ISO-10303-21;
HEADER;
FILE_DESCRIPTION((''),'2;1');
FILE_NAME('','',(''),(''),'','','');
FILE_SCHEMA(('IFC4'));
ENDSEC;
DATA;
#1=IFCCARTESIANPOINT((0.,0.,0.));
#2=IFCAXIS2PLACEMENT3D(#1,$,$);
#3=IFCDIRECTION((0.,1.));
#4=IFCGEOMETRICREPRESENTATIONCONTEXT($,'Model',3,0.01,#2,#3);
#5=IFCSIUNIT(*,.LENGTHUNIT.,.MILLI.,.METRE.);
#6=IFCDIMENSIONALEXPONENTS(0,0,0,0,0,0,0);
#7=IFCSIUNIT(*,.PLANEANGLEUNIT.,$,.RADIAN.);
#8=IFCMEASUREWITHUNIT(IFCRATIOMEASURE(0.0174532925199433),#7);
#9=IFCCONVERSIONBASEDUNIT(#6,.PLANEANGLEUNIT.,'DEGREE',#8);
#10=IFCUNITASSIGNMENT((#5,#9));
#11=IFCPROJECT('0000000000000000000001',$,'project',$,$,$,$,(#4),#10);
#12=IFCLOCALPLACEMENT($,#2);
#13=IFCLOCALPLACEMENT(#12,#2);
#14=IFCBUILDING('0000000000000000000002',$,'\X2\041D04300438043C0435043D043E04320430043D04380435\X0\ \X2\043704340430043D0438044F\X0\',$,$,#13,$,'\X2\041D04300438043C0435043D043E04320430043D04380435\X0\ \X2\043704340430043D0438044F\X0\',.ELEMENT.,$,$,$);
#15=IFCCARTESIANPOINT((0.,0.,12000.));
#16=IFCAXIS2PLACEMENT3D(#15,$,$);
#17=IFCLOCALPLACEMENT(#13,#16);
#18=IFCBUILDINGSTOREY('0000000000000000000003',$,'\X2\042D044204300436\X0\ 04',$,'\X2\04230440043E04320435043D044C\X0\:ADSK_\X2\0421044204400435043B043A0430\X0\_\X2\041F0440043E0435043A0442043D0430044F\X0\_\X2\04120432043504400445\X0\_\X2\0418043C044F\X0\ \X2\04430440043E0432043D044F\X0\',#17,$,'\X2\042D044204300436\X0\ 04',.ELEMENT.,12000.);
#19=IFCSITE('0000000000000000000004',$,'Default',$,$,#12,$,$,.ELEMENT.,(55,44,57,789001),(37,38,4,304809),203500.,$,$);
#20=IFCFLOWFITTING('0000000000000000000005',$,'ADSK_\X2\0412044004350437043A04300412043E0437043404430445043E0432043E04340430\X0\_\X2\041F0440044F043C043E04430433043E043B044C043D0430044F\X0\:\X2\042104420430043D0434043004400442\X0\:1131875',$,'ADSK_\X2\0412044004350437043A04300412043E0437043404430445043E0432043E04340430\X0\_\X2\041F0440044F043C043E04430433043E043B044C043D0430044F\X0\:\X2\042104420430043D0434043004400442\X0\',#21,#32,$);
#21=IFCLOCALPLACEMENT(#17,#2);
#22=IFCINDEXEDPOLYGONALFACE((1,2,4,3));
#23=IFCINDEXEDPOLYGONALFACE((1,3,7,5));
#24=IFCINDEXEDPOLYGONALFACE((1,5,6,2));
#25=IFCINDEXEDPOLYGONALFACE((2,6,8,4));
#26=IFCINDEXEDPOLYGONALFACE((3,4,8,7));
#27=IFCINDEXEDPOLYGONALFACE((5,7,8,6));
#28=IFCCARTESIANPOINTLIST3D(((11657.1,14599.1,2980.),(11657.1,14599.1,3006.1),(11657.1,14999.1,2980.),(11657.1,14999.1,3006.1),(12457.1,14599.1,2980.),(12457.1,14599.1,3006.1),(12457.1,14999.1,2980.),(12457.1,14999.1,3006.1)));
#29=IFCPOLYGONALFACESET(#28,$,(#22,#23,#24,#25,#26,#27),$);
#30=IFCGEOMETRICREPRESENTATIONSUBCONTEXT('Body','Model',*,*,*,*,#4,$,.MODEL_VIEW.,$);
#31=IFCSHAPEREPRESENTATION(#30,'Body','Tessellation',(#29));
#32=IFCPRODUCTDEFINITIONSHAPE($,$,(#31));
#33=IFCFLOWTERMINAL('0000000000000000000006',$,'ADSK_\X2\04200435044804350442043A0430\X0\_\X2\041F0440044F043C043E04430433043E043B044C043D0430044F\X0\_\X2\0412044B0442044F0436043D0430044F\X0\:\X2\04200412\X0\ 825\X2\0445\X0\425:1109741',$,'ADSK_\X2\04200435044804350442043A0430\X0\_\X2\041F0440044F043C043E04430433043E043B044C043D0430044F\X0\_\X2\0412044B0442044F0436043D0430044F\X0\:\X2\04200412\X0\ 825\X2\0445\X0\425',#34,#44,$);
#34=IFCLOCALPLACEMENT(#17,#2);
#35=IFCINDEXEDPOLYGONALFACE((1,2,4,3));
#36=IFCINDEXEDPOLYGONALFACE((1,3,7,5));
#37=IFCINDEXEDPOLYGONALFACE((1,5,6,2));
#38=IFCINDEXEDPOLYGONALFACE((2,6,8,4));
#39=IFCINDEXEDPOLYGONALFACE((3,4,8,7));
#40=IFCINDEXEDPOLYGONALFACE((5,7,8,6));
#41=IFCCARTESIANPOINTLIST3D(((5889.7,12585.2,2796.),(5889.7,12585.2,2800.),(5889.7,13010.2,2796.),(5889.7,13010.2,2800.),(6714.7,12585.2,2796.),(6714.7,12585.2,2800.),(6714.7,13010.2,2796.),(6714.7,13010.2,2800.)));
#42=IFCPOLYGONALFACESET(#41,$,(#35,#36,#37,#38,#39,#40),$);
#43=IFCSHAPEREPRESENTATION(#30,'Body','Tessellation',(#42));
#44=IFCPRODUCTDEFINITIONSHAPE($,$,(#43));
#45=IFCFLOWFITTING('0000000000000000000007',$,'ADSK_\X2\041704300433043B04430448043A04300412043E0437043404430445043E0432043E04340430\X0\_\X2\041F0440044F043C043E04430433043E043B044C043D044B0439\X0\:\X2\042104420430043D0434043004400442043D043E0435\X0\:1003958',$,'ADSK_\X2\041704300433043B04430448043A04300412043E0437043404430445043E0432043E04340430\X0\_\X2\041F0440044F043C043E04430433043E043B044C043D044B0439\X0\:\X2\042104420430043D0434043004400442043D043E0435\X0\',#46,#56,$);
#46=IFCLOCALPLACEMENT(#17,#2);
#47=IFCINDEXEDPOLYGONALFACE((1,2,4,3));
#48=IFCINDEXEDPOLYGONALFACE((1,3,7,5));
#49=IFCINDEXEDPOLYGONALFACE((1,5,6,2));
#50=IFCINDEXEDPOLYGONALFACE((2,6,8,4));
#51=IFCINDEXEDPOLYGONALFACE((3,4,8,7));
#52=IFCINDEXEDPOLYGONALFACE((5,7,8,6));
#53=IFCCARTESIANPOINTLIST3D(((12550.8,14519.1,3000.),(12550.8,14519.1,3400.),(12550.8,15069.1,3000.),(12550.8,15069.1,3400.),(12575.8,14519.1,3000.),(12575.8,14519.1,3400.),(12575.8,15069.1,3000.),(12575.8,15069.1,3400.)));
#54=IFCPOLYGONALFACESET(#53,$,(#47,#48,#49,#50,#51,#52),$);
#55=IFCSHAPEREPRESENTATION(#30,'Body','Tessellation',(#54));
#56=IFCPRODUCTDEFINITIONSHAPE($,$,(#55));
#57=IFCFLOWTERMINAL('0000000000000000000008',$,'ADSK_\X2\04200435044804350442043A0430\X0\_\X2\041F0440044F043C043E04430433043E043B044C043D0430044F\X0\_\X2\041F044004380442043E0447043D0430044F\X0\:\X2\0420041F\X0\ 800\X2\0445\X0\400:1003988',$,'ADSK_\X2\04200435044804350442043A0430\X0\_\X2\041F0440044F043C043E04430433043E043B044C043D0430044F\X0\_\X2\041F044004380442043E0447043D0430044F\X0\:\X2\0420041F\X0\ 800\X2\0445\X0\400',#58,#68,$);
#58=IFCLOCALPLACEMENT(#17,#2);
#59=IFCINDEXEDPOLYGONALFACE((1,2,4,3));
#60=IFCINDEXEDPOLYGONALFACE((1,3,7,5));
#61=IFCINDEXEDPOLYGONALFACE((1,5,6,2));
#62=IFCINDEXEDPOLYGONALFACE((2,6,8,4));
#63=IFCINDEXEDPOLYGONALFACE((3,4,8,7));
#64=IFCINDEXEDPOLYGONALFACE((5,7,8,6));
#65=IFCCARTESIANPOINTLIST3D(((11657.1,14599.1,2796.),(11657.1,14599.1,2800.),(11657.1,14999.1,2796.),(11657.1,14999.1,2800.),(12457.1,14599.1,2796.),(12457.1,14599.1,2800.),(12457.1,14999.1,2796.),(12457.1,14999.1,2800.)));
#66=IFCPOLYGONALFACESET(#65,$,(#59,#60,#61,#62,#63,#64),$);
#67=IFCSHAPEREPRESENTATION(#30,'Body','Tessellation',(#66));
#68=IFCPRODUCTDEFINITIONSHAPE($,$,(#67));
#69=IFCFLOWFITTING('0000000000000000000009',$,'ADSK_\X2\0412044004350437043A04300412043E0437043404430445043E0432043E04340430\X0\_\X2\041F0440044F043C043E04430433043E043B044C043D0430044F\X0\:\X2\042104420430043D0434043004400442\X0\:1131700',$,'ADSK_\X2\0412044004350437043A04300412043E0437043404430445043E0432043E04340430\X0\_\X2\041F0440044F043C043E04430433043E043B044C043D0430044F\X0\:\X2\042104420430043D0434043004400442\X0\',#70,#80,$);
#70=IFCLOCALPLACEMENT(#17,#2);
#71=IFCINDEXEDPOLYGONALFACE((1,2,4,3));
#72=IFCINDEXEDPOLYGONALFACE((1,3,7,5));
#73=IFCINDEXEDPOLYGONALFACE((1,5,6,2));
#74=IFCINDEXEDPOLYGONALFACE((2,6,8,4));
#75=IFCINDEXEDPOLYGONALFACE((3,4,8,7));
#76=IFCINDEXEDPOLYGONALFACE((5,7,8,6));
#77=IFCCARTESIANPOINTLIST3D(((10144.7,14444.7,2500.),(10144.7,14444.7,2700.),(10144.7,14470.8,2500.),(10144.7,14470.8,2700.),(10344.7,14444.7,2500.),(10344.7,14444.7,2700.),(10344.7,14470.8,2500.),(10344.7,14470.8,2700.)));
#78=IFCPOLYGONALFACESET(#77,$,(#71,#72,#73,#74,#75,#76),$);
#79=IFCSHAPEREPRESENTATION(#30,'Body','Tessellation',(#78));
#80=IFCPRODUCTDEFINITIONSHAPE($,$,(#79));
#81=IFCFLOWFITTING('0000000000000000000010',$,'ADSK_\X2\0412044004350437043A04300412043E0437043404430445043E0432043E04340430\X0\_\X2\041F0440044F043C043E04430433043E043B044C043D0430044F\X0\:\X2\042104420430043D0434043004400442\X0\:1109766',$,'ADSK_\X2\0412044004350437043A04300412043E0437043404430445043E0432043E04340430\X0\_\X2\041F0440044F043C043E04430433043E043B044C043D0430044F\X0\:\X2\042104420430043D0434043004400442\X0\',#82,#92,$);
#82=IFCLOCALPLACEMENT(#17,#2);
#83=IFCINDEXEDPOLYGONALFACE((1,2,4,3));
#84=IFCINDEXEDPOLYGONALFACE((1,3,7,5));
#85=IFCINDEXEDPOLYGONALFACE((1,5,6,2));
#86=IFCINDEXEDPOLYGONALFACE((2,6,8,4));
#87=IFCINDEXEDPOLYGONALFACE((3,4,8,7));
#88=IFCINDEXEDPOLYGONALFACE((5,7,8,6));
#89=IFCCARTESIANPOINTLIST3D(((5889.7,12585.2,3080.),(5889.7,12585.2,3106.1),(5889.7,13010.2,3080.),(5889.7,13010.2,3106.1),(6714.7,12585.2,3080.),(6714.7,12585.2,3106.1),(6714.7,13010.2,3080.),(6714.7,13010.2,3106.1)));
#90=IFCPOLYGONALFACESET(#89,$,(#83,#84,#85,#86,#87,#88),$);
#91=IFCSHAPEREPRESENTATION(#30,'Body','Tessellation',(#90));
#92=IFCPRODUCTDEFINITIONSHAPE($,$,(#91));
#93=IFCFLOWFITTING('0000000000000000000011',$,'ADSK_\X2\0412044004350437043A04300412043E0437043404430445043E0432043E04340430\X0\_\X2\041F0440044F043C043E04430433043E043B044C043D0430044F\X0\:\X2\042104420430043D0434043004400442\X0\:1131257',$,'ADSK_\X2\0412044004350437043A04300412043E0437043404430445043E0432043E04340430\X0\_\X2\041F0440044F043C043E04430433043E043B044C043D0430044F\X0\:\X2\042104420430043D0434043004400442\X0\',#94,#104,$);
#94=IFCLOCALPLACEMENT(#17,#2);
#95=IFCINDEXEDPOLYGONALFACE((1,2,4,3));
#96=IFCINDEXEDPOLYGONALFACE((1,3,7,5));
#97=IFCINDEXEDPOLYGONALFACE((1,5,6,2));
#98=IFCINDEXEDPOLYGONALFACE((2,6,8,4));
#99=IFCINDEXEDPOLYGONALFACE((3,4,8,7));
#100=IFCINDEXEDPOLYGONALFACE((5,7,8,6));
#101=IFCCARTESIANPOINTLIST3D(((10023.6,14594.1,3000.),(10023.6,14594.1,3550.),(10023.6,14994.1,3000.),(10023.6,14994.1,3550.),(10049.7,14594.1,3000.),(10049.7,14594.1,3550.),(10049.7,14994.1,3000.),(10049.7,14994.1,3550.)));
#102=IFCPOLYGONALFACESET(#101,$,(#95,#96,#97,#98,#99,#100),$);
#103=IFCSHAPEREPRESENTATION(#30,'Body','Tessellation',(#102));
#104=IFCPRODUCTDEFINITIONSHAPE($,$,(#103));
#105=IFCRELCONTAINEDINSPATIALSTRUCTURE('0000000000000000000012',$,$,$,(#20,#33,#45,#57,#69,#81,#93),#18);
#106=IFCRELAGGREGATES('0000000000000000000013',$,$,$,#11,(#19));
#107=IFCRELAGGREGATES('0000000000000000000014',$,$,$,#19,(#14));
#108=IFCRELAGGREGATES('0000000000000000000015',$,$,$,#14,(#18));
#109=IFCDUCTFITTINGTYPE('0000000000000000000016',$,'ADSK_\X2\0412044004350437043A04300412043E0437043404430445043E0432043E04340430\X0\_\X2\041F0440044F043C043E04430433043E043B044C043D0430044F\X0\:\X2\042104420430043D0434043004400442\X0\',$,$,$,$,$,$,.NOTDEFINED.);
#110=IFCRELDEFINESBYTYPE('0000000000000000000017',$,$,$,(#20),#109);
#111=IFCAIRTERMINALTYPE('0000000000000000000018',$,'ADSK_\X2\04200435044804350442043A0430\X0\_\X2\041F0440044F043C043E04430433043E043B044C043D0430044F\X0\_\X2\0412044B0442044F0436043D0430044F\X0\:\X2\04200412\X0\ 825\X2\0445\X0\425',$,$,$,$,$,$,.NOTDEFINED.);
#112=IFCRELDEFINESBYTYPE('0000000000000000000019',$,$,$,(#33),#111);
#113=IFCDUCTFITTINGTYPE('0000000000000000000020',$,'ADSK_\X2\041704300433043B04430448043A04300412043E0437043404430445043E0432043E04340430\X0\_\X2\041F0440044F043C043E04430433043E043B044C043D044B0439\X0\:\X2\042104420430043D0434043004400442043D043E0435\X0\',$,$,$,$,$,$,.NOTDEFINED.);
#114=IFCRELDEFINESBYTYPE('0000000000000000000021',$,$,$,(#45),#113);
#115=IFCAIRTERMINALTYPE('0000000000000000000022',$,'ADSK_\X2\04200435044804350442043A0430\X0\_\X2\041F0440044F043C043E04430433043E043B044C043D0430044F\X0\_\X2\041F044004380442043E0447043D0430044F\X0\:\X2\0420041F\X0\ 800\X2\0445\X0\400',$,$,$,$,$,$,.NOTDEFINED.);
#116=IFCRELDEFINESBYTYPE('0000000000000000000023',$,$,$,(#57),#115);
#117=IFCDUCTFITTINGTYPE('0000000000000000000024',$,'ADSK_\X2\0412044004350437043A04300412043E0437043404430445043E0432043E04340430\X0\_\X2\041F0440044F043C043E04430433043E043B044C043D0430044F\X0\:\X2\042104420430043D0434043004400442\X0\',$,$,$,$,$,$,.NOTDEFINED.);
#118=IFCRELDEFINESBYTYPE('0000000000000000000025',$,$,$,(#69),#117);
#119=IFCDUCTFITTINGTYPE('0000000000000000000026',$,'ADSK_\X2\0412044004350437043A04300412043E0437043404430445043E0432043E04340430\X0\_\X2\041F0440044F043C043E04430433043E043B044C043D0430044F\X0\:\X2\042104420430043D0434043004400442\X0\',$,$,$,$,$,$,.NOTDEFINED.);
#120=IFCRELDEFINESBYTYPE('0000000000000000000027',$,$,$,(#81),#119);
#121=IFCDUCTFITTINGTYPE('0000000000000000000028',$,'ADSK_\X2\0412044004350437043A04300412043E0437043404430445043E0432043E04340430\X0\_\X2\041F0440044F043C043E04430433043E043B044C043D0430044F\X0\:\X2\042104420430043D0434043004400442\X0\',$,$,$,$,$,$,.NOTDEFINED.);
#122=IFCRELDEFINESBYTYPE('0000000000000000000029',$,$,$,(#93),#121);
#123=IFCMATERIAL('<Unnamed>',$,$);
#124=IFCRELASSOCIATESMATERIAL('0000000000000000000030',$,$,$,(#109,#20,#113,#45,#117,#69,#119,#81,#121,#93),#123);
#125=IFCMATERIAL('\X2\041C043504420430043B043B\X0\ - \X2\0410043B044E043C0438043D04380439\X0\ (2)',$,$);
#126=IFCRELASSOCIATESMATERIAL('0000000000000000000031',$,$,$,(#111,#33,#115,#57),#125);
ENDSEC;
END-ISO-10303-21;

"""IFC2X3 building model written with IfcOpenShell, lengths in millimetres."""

from ifc_helpers import new_model, entity, si_unit, converted_unit, direction, frame, frame_2d, origin, origin_2d_with_axis, place, context, subcontext, project, spatial, rectangle, extrude, source, transform, mapped, material, type_object, type_shapes, element, save


model = new_model("IFC2X3")

# Units and contexts
model_context = context("Model", 3, precision=0.01, world=origin(), true_north=direction((0.0, 1.0)))
body_context = subcontext(model_context, "Body", "Model", "MODEL_VIEW")
ifc_project = project(units=[si_unit("LENGTHUNIT", "METRE", prefix="MILLI"), converted_unit("PLANEANGLEUNIT", "DEGREE", entity("IfcRatioMeasure", 0.0174532925199433), si_unit("PLANEANGLEUNIT", "RADIAN"), dimensions=[0, 0, 0, 0, 0, 0, 0])], contexts=[model_context])

# Site, building, storey
site_placement = place(None, frame((0.0, 0.0, 0.0)))
site = spatial("IfcSite", under=ifc_project, at=site_placement, Name="Default", CompositionType="ELEMENT", RefLatitude=(55, 44, 57, 789001), RefLongitude=(37, 38, 4, 304809), RefElevation=203500.0)
building_placement = place(site_placement, origin())
building = spatial("IfcBuilding", under=site, at=building_placement, Name="Наименование здания", LongName="Наименование здания", CompositionType="ELEMENT")
storey_placement = place(building_placement, frame((0.0, 0.0, 12000.0)))
storey = spatial("IfcBuildingStorey", under=building, at=storey_placement, Name="Этаж 04", ObjectType="Уровень:ADSK_Стрелка_Проектная_Вверх_Имя уровня", LongName="Этаж 04", CompositionType="ELEMENT", Elevation=12000.0)

# Flow fitting
ifc_material_1 = material(Name="<Unnamed>")
duct_fitting_type_1 = type_object("IfcDuctFittingType", Name="ADSK_ВрезкаВоздуховода_Прямоугольная:Стандарт", PredefinedType="NOTDEFINED", material=ifc_material_1)
shared_shape_1 = source(origin(), body_context, "Body", "SweptSolid", [
    extrude(rectangle(XDim=800.0, YDim=26.1, at=frame_2d((0.0, 0.0), x_axis=(1.0, 0.0))), frame((7.0, 0.0, -200.0), z_axis=(0.0, 0.0, 1.0), x_axis=(0.0, -1.0, 0.0)), (0.0, 0.0, 1.0), 400.0),
])
type_shapes(duct_fitting_type_1, [shared_shape_1])
flow_fitting_1_placement = place(storey_placement, frame((12057.1, 14799.1, 3000.0), z_axis=(0.0, 1.0, 0.0), x_axis=(0.0, 0.0, -1.0)))
element("IfcFlowFitting", 1, at=flow_fitting_1_placement, inside=storey, type_object=duct_fitting_type_1, material=ifc_material_1, Name="ADSK_ВрезкаВоздуховода_Прямоугольная:Стандарт:1131875", ObjectType="ADSK_ВрезкаВоздуховода_Прямоугольная:Стандарт", context=body_context, shape_type="MappedRepresentation", body=[
    mapped(shared_shape_1, transform((0.0, 0.0, 0.0), scale=1.0)),
])

# Flow terminal
ifc_material_2 = material(Name="Металл - Алюминий (2)")
air_terminal_type_1 = type_object("IfcAirTerminalType", Name="ADSK_Решетка_Прямоугольная_Вытяжная:РВ 825х425", PredefinedType="NOTDEFINED", material=ifc_material_2)
shared_shape_2 = source(origin(), body_context, "Body", "SweptSolid", [
    extrude(rectangle(XDim=4.0, YDim=825.0, at=origin_2d_with_axis()), frame((0.0, -2.0, -212.5), z_axis=(0.0, 0.0, 1.0), x_axis=(0.0, 1.0, 0.0)), (0.0, 0.0, 1.0), 425.0),
])
type_shapes(air_terminal_type_1, [shared_shape_2])
flow_terminal_1_placement = place(storey_placement, frame((6302.2, 12797.7, 2800.0), z_axis=(0.0, 1.0, 0.0), x_axis=(-1.0, 0.0, 0.0)))
element("IfcFlowTerminal", 2, at=flow_terminal_1_placement, inside=storey, type_object=air_terminal_type_1, material=ifc_material_2, Name="ADSK_Решетка_Прямоугольная_Вытяжная:РВ 825х425:1109741", ObjectType="ADSK_Решетка_Прямоугольная_Вытяжная:РВ 825х425", context=body_context, shape_type="MappedRepresentation", body=[
    mapped(shared_shape_2, transform((0.0, 0.0, 0.0), scale=1.0)),
])

# Flow fitting
duct_fitting_type_2 = type_object("IfcDuctFittingType", Name="ADSK_ЗаглушкаВоздуховода_Прямоугольный:Стандартное", PredefinedType="NOTDEFINED", material=ifc_material_1)
shared_shape_3 = source(origin(), body_context, "Body", "SweptSolid", [
    extrude(rectangle(XDim=25.0, YDim=550.0, at=frame_2d((0.0, 0.0), x_axis=(1.0, 0.0))), frame((12.5, 0.0, -200.0)), (0.0, 0.0, 1.0), 400.0),
])
type_shapes(duct_fitting_type_2, [shared_shape_3])
flow_fitting_2_placement = place(storey_placement, frame((12550.8, 14794.1, 3200.0)))
element("IfcFlowFitting", 3, at=flow_fitting_2_placement, inside=storey, type_object=duct_fitting_type_2, material=ifc_material_1, Name="ADSK_ЗаглушкаВоздуховода_Прямоугольный:Стандартное:1003958", ObjectType="ADSK_ЗаглушкаВоздуховода_Прямоугольный:Стандартное", context=body_context, shape_type="MappedRepresentation", body=[
    mapped(shared_shape_3, transform((0.0, 0.0, 0.0), scale=1.0)),
])

# Flow terminal
air_terminal_type_2 = type_object("IfcAirTerminalType", Name="ADSK_Решетка_Прямоугольная_Приточная:РП 800х400", PredefinedType="NOTDEFINED", material=ifc_material_2)
shared_shape_4 = source(origin(), body_context, "Body", "SweptSolid", [
    extrude(rectangle(XDim=4.0, YDim=800.0, at=origin_2d_with_axis()), frame((0.0, -2.0, -200.0), z_axis=(0.0, 0.0, 1.0), x_axis=(0.0, 1.0, 0.0)), (0.0, 0.0, 1.0), 400.0),
])
type_shapes(air_terminal_type_2, [shared_shape_4])
flow_terminal_2_placement = place(storey_placement, frame((12057.1, 14799.1, 2800.0), z_axis=(0.0, 1.0, 0.0), x_axis=(-1.0, 0.0, 0.0)))
element("IfcFlowTerminal", 4, at=flow_terminal_2_placement, inside=storey, type_object=air_terminal_type_2, material=ifc_material_2, Name="ADSK_Решетка_Прямоугольная_Приточная:РП 800х400:1003988", ObjectType="ADSK_Решетка_Прямоугольная_Приточная:РП 800х400", context=body_context, shape_type="MappedRepresentation", body=[
    mapped(shared_shape_4, transform((0.0, 0.0, 0.0), scale=1.0)),
])

# Flow fittings
duct_fitting_type_3 = type_object("IfcDuctFittingType", Name="ADSK_ВрезкаВоздуховода_Прямоугольная:Стандарт", PredefinedType="NOTDEFINED", material=ifc_material_1)
shared_shape_5 = source(origin(), body_context, "Body", "SweptSolid", [
    extrude(rectangle(XDim=200.0, YDim=26.1, at=frame_2d((0.0, 0.0), x_axis=(1.0, 0.0))), frame((7.0, 0.0, -100.0), z_axis=(0.0, 0.0, 1.0), x_axis=(0.0, -1.0, 0.0)), (0.0, 0.0, 1.0), 200.0),
])
type_shapes(duct_fitting_type_3, [shared_shape_5])
flow_fitting_3_placement = place(storey_placement, frame((10244.7, 14450.8, 2600.0), z_axis=(1.0, 0.0, 0.0), x_axis=(0.0, 1.0, 0.0)))
element("IfcFlowFitting", 5, at=flow_fitting_3_placement, inside=storey, type_object=duct_fitting_type_3, material=ifc_material_1, Name="ADSK_ВрезкаВоздуховода_Прямоугольная:Стандарт:1131700", ObjectType="ADSK_ВрезкаВоздуховода_Прямоугольная:Стандарт", context=body_context, shape_type="MappedRepresentation", body=[
    mapped(shared_shape_5, transform((0.0, 0.0, 0.0), scale=1.0)),
])
duct_fitting_type_4 = type_object("IfcDuctFittingType", Name="ADSK_ВрезкаВоздуховода_Прямоугольная:Стандарт", PredefinedType="NOTDEFINED", material=ifc_material_1)
shared_shape_6 = source(origin(), body_context, "Body", "SweptSolid", [
    extrude(rectangle(XDim=825.0, YDim=26.1, at=frame_2d((0.0, 0.0), x_axis=(1.0, 0.0))), frame((7.0, 0.0, -212.5), z_axis=(0.0, 0.0, 1.0), x_axis=(0.0, -1.0, 0.0)), (0.0, 0.0, 1.0), 425.0),
])
type_shapes(duct_fitting_type_4, [shared_shape_6])
flow_fitting_4_placement = place(storey_placement, frame((6302.2, 12797.7, 3100.0), z_axis=(0.0, -1.0, 0.0), x_axis=(0.0, 0.0, -1.0)))
element("IfcFlowFitting", 6, at=flow_fitting_4_placement, inside=storey, type_object=duct_fitting_type_4, material=ifc_material_1, Name="ADSK_ВрезкаВоздуховода_Прямоугольная:Стандарт:1109766", ObjectType="ADSK_ВрезкаВоздуховода_Прямоугольная:Стандарт", context=body_context, shape_type="MappedRepresentation", body=[
    mapped(shared_shape_6, transform((0.0, 0.0, 0.0), scale=1.0)),
])
duct_fitting_type_5 = type_object("IfcDuctFittingType", Name="ADSK_ВрезкаВоздуховода_Прямоугольная:Стандарт", PredefinedType="NOTDEFINED", material=ifc_material_1)
shared_shape_7 = source(origin(), body_context, "Body", "SweptSolid", [
    extrude(rectangle(XDim=550.0, YDim=26.1, at=origin_2d_with_axis()), frame((7.0, 0.0, -200.0), z_axis=(0.0, 0.0, 1.0), x_axis=(0.0, -1.0, 0.0)), (0.0, 0.0, 1.0), 400.0),
])
type_shapes(duct_fitting_type_5, [shared_shape_7])
flow_fitting_5_placement = place(storey_placement, frame((10029.7, 14794.1, 3275.0), z_axis=(0.0, -1.0, 0.0), x_axis=(1.0, 0.0, 0.0)))
element("IfcFlowFitting", 7, at=flow_fitting_5_placement, inside=storey, type_object=duct_fitting_type_5, material=ifc_material_1, Name="ADSK_ВрезкаВоздуховода_Прямоугольная:Стандарт:1131257", ObjectType="ADSK_ВрезкаВоздуховода_Прямоугольная:Стандарт", context=body_context, shape_type="MappedRepresentation", body=[
    mapped(shared_shape_7, transform((0.0, 0.0, 0.0), scale=1.0)),
])

save(model, "model.ifc")
